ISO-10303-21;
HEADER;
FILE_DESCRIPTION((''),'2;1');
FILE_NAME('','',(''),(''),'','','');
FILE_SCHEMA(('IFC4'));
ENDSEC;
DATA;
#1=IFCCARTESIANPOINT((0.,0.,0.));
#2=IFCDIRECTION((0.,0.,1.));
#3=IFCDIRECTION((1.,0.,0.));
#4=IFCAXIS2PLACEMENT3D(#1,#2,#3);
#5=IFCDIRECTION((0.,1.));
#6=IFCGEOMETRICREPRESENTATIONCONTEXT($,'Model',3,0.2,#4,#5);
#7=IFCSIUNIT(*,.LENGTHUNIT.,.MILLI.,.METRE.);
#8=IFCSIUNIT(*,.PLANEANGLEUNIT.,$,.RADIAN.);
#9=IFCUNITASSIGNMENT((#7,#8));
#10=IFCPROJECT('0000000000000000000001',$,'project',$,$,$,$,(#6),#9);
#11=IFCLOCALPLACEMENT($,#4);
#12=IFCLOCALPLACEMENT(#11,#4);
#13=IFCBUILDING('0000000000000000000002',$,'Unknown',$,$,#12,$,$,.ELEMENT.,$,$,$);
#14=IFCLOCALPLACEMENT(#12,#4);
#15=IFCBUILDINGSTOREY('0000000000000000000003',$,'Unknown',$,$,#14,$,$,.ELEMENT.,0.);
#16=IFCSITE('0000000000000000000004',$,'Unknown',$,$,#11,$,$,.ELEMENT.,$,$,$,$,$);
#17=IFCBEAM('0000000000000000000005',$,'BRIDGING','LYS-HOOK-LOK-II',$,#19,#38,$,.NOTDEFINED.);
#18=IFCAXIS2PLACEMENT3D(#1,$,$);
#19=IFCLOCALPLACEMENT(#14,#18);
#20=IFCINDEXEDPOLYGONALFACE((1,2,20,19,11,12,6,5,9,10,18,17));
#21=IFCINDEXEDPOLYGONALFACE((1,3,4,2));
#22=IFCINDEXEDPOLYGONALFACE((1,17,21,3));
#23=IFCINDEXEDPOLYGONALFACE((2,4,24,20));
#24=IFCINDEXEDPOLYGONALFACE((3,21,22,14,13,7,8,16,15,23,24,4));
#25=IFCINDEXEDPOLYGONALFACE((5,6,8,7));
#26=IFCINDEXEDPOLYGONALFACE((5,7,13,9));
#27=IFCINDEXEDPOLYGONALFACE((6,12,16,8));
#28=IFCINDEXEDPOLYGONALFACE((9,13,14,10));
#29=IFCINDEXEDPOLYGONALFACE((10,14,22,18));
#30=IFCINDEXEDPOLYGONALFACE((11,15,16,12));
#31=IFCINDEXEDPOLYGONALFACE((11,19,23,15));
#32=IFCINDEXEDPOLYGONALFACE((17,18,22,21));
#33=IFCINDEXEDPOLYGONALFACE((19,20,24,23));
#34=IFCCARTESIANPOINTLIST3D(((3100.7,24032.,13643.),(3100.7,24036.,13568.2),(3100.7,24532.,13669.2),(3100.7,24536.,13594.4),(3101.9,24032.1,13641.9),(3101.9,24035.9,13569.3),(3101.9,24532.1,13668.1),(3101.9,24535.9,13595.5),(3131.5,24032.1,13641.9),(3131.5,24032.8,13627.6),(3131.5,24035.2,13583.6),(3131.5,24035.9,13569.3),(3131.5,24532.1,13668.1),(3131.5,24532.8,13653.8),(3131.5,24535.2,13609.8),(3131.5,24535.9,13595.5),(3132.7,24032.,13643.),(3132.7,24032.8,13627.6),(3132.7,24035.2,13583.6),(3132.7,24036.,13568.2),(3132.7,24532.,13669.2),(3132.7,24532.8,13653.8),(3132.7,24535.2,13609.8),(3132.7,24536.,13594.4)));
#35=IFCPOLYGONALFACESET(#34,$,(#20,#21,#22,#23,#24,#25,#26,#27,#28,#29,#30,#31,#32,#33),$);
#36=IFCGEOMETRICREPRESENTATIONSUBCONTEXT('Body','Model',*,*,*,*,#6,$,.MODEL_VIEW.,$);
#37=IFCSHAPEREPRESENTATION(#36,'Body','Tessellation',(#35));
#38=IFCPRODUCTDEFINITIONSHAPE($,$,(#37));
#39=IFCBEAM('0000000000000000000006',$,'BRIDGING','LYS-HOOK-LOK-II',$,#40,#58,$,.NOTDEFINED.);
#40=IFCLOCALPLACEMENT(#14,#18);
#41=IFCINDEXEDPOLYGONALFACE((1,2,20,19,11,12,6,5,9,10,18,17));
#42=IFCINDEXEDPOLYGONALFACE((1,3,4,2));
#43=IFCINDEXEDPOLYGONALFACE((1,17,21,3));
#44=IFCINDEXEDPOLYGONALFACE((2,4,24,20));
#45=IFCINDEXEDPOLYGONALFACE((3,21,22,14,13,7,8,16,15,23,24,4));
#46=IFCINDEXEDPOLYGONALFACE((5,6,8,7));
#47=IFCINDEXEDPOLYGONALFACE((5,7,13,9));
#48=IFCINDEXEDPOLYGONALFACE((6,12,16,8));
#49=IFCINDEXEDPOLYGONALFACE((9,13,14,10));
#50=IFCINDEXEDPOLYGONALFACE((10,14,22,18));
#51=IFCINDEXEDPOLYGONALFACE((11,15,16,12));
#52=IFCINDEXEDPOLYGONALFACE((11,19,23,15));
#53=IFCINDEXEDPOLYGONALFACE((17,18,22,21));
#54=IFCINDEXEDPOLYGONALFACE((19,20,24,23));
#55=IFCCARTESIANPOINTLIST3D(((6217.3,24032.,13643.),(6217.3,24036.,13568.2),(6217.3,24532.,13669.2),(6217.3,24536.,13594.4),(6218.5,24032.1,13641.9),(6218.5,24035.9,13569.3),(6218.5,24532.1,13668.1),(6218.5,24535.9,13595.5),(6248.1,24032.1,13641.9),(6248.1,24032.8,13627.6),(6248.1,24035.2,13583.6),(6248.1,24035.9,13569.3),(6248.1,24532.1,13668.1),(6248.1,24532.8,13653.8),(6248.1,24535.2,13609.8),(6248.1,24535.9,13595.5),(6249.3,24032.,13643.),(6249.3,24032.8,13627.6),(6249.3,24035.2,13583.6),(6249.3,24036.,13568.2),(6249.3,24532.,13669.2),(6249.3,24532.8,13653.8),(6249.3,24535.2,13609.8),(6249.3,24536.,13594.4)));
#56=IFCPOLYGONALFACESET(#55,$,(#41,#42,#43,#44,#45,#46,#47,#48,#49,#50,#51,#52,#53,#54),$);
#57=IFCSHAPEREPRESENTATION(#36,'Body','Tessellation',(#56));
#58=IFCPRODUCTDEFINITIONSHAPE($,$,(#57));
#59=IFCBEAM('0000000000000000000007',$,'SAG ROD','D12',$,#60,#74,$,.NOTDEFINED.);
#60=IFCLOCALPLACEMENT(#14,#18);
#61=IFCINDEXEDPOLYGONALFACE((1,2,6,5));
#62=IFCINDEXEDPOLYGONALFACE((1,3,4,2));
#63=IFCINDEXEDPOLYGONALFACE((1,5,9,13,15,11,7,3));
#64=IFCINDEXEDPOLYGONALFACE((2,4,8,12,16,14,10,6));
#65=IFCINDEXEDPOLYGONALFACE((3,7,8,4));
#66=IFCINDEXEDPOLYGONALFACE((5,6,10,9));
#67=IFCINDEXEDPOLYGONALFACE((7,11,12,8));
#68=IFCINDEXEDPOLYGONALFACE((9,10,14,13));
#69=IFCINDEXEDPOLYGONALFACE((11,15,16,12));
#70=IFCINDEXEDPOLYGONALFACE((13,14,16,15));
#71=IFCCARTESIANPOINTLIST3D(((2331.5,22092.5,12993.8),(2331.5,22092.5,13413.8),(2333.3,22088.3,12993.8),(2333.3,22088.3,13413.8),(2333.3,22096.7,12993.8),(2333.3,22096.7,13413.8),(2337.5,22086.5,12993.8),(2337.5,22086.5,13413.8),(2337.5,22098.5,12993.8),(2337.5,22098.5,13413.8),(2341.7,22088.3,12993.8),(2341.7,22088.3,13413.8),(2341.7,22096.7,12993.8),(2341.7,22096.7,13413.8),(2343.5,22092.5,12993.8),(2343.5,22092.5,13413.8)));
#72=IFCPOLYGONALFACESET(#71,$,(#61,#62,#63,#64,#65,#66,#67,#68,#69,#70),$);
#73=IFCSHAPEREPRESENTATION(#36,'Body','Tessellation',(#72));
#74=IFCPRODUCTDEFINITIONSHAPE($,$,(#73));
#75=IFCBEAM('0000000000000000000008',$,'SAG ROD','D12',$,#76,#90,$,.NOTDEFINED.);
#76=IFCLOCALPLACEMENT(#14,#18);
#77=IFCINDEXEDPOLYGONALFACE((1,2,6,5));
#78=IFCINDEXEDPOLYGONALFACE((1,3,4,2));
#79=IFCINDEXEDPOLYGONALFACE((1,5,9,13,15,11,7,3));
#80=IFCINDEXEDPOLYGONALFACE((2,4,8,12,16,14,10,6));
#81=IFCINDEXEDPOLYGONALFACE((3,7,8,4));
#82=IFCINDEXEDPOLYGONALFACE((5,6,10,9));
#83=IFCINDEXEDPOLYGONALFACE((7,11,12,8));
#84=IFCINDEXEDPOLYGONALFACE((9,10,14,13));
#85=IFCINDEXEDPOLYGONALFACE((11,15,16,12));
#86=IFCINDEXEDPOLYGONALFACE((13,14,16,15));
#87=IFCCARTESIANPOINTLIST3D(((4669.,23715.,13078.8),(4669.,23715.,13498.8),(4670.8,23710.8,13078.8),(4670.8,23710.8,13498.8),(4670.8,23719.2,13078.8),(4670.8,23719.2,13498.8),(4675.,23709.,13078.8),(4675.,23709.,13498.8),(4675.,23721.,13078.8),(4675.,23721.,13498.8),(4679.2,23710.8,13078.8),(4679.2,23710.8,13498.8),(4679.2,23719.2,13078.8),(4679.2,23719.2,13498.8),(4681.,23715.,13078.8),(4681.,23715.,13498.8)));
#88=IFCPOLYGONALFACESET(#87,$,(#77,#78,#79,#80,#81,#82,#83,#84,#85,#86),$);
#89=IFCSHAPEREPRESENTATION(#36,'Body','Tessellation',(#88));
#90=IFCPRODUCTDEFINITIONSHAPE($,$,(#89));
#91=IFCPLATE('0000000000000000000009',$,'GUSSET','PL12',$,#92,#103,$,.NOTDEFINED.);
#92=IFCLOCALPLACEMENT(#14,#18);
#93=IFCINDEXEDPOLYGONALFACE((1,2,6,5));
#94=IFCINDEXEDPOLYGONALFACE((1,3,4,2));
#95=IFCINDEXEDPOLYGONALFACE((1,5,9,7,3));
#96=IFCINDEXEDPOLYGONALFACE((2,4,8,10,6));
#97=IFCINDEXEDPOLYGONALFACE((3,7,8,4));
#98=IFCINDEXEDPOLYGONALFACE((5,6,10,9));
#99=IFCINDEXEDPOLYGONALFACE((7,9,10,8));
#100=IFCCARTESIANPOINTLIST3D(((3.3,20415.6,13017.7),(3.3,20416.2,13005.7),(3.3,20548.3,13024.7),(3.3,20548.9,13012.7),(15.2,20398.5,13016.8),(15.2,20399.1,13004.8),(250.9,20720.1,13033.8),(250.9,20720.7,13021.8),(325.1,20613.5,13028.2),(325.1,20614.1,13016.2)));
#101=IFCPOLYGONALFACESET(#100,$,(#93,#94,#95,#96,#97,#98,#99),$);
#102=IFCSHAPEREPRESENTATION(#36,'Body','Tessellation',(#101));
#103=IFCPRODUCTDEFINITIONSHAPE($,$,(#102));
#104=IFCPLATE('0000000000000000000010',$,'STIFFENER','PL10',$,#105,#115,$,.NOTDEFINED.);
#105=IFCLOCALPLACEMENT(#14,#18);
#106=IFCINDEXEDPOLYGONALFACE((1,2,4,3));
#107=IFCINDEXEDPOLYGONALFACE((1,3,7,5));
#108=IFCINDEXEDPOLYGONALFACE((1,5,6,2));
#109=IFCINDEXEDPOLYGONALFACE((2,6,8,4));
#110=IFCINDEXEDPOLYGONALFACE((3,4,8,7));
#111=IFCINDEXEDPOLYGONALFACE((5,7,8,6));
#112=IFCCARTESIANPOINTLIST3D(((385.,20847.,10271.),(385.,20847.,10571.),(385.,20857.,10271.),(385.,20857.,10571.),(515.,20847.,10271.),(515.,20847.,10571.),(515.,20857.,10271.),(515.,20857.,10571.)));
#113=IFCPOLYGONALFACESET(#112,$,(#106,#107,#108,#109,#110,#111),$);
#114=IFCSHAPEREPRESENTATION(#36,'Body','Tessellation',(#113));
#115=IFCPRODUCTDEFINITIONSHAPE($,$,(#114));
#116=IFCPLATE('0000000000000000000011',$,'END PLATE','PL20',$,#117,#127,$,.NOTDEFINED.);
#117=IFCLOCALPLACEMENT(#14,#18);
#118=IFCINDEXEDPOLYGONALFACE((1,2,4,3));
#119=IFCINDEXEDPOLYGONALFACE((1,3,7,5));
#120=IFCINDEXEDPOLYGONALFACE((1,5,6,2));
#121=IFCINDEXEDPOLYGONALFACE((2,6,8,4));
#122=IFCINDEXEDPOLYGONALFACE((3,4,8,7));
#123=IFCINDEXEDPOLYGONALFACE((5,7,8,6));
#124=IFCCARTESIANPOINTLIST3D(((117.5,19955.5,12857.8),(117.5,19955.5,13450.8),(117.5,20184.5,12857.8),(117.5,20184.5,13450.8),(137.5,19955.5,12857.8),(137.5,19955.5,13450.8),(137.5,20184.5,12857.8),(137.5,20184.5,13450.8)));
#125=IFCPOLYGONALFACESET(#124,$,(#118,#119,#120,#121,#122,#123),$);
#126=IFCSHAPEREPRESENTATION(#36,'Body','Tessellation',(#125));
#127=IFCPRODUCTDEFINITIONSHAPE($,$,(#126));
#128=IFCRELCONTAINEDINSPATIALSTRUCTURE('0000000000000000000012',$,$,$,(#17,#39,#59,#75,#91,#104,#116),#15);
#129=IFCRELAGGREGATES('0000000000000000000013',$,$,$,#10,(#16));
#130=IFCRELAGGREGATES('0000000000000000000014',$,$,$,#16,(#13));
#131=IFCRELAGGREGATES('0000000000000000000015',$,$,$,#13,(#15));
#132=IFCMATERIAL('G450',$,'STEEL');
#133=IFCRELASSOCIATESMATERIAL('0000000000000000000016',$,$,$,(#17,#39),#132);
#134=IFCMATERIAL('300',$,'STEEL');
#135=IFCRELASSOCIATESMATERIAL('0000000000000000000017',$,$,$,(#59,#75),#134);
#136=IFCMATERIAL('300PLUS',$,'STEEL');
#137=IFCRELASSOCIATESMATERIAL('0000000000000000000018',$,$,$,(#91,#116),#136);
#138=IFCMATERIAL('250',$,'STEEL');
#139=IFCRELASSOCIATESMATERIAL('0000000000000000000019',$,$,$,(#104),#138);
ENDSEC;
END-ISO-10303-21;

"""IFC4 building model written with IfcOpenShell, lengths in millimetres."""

from ifc_helpers import new_model, si_unit, direction, frame, origin_with_axes, place, context, subcontext, project, spatial, line, indexed_curve, outline, extrude, material, element, save


model = new_model("IFC4")

# Units and contexts
model_context = context("Model", 3, precision=0.2, world=origin_with_axes(), true_north=direction((0.0, 1.0)))
body_context = subcontext(model_context, "Body", "Model", "MODEL_VIEW")
ifc_project = project(units=[si_unit("LENGTHUNIT", "METRE", prefix="MILLI"), si_unit("PLANEANGLEUNIT", "RADIAN")], contexts=[model_context])

# Site, building, storey
site_placement = place(None, origin_with_axes())
site = spatial("IfcSite", under=ifc_project, at=site_placement, Name="Unknown", CompositionType="ELEMENT")
building_placement = place(site_placement, origin_with_axes())
building = spatial("IfcBuilding", under=site, at=building_placement, Name="Unknown", CompositionType="ELEMENT")
storey_placement = place(building_placement, origin_with_axes())
storey = spatial("IfcBuildingStorey", under=building, at=storey_placement, Name="Unknown", CompositionType="ELEMENT", Elevation=0.0)

# Beams
ifc_material_1 = material(Name="300PLUS", Category="STEEL")
ifc_material_2 = material(Name="G450", Category="STEEL")
for number, where, z_axis, x_axis, name in (
    (1, (3116.7, 24034.0, 13605.6), (1.0, 0.0, 0.0), (0.0, 0.99863, 0.052328), "BRIDGING"),
    (2, (6233.3, 24034.0, 13605.6), (1.0, 0.0, 0.0), (0.0, 0.99863, 0.052328), "BRIDGING"),
):
    element("IfcBeam", number, at=place(storey_placement, frame(where, z_axis=z_axis, x_axis=x_axis)), inside=storey, material=ifc_material_2, Name=name, Description="LYS-HOOK-LOK-II", PredefinedType="NOTDEFINED", context=body_context, shape_type="SolidModel", body=[
        extrude(outline(indexed_curve([(16.0, -37.5), (16.0, -22.0), (14.8, -22.0), (14.8, -36.3), (-14.8, -36.3), (-14.8, 36.3), (14.8, 36.3), (14.8, 22.0), (16.0, 22.0), (16.0, 37.5), (-16.0, 37.5), (-16.0, -37.5)], segments=[line(1, 2, 3, 4, 5, 6, 7, 8, 9, 10, 11, 12, 1)])), frame((0.0, 0.0, 0.0), z_axis=(-1.0, 0.0, 0.0), x_axis=(0.0, 0.0, 1.0)), (0.0, 0.0, -1.0), 500.7),
    ])
ifc_material_3 = material(Name="300", Category="STEEL")
for number, where, z_axis, x_axis, name in (
    (3, (2337.5, 22092.5, 13413.8), (1.0, 0.0, 0.0), (0.0, 0.0, -1.0), "SAG ROD"),
    (4, (4675.0, 23715.0, 13498.8), (1.0, 0.0, 0.0), (0.0, 0.0, -1.0), "SAG ROD"),
):
    element("IfcBeam", number, at=place(storey_placement, frame(where, z_axis=z_axis, x_axis=x_axis)), inside=storey, material=ifc_material_3, Name=name, Description="D12", PredefinedType="NOTDEFINED", context=body_context, shape_type="SolidModel", body=[
        extrude(outline(indexed_curve([(6.0, 0.0), (4.2, 4.2), (0.0, 6.0), (-4.2, 4.2), (-6.0, 0.0), (-4.2, -4.2), (0.0, -6.0), (4.2, -4.2)], segments=[line(1, 2, 3, 4, 5, 6, 7, 8, 1)])), frame((0.0, 0.0, 0.0), z_axis=(-1.0, 0.0, 0.0), x_axis=(0.0, 0.0, 1.0)), (0.0, 0.0, -1.0), 420.0),
    ])

# Plates
plate_1_placement = place(storey_placement, frame((3.3, 20415.9, 13011.7), z_axis=(-0.000171, -0.052677, 0.998612), x_axis=(0.570673, -0.820042, -0.04316)))
element("IfcPlate", 5, at=plate_1_placement, inside=storey, material=ifc_material_1, Name="GUSSET", Description="PL12", PredefinedType="NOTDEFINED", context=body_context, shape_type="SolidModel", body=[
    extrude(outline(indexed_curve([(0.0, 0.0), (20.9, 0.0), (20.9, 377.3), (-109.1, 377.3), (-109.1, 75.8)], segments=[line(1, 2, 3, 4, 5, 1)])), frame((0.0, 0.0, 6.0), z_axis=(0.0, 0.0, 1.0), x_axis=(1.0, 0.0, 0.0)), (0.0, 0.0, -1.0), 12.0),
])
ifc_material_4 = material(Name="250", Category="STEEL")
plate_2_placement = place(storey_placement, frame((385.0, 20852.0, 10571.0), z_axis=(0.0, 1.0, 0.0), x_axis=(1.0, 0.0, 0.0)))
element("IfcPlate", 6, at=plate_2_placement, inside=storey, material=ifc_material_4, Name="STIFFENER", Description="PL10", PredefinedType="NOTDEFINED", context=body_context, shape_type="SolidModel", body=[
    extrude(outline(indexed_curve([(0.0, 0.0), (130.0, 0.0), (130.0, 300.0), (0.0, 300.0)], segments=[line(1, 2, 3, 4, 1)])), frame((0.0, 0.0, 5.0), z_axis=(0.0, 0.0, 1.0), x_axis=(1.0, 0.0, 0.0)), (0.0, 0.0, -1.0), 10.0),
])
plate_3_placement = place(storey_placement, frame((127.5, 20184.5, 12857.8), z_axis=(-1.0, 0.0, 0.0), x_axis=(0.0, -1.0, 0.0)))
element("IfcPlate", 7, at=plate_3_placement, inside=storey, material=ifc_material_1, Name="END PLATE", Description="PL20", PredefinedType="NOTDEFINED", context=body_context, shape_type="SolidModel", body=[
    extrude(outline(indexed_curve([(0.0, 0.0), (229.0, 0.0), (229.0, 593.0), (0.0, 593.0)], segments=[line(1, 2, 3, 4, 1)])), frame((0.0, 0.0, 10.0), z_axis=(0.0, 0.0, 1.0), x_axis=(1.0, 0.0, 0.0)), (0.0, 0.0, -1.0), 20.0),
])

save(model, "model.ifc")
